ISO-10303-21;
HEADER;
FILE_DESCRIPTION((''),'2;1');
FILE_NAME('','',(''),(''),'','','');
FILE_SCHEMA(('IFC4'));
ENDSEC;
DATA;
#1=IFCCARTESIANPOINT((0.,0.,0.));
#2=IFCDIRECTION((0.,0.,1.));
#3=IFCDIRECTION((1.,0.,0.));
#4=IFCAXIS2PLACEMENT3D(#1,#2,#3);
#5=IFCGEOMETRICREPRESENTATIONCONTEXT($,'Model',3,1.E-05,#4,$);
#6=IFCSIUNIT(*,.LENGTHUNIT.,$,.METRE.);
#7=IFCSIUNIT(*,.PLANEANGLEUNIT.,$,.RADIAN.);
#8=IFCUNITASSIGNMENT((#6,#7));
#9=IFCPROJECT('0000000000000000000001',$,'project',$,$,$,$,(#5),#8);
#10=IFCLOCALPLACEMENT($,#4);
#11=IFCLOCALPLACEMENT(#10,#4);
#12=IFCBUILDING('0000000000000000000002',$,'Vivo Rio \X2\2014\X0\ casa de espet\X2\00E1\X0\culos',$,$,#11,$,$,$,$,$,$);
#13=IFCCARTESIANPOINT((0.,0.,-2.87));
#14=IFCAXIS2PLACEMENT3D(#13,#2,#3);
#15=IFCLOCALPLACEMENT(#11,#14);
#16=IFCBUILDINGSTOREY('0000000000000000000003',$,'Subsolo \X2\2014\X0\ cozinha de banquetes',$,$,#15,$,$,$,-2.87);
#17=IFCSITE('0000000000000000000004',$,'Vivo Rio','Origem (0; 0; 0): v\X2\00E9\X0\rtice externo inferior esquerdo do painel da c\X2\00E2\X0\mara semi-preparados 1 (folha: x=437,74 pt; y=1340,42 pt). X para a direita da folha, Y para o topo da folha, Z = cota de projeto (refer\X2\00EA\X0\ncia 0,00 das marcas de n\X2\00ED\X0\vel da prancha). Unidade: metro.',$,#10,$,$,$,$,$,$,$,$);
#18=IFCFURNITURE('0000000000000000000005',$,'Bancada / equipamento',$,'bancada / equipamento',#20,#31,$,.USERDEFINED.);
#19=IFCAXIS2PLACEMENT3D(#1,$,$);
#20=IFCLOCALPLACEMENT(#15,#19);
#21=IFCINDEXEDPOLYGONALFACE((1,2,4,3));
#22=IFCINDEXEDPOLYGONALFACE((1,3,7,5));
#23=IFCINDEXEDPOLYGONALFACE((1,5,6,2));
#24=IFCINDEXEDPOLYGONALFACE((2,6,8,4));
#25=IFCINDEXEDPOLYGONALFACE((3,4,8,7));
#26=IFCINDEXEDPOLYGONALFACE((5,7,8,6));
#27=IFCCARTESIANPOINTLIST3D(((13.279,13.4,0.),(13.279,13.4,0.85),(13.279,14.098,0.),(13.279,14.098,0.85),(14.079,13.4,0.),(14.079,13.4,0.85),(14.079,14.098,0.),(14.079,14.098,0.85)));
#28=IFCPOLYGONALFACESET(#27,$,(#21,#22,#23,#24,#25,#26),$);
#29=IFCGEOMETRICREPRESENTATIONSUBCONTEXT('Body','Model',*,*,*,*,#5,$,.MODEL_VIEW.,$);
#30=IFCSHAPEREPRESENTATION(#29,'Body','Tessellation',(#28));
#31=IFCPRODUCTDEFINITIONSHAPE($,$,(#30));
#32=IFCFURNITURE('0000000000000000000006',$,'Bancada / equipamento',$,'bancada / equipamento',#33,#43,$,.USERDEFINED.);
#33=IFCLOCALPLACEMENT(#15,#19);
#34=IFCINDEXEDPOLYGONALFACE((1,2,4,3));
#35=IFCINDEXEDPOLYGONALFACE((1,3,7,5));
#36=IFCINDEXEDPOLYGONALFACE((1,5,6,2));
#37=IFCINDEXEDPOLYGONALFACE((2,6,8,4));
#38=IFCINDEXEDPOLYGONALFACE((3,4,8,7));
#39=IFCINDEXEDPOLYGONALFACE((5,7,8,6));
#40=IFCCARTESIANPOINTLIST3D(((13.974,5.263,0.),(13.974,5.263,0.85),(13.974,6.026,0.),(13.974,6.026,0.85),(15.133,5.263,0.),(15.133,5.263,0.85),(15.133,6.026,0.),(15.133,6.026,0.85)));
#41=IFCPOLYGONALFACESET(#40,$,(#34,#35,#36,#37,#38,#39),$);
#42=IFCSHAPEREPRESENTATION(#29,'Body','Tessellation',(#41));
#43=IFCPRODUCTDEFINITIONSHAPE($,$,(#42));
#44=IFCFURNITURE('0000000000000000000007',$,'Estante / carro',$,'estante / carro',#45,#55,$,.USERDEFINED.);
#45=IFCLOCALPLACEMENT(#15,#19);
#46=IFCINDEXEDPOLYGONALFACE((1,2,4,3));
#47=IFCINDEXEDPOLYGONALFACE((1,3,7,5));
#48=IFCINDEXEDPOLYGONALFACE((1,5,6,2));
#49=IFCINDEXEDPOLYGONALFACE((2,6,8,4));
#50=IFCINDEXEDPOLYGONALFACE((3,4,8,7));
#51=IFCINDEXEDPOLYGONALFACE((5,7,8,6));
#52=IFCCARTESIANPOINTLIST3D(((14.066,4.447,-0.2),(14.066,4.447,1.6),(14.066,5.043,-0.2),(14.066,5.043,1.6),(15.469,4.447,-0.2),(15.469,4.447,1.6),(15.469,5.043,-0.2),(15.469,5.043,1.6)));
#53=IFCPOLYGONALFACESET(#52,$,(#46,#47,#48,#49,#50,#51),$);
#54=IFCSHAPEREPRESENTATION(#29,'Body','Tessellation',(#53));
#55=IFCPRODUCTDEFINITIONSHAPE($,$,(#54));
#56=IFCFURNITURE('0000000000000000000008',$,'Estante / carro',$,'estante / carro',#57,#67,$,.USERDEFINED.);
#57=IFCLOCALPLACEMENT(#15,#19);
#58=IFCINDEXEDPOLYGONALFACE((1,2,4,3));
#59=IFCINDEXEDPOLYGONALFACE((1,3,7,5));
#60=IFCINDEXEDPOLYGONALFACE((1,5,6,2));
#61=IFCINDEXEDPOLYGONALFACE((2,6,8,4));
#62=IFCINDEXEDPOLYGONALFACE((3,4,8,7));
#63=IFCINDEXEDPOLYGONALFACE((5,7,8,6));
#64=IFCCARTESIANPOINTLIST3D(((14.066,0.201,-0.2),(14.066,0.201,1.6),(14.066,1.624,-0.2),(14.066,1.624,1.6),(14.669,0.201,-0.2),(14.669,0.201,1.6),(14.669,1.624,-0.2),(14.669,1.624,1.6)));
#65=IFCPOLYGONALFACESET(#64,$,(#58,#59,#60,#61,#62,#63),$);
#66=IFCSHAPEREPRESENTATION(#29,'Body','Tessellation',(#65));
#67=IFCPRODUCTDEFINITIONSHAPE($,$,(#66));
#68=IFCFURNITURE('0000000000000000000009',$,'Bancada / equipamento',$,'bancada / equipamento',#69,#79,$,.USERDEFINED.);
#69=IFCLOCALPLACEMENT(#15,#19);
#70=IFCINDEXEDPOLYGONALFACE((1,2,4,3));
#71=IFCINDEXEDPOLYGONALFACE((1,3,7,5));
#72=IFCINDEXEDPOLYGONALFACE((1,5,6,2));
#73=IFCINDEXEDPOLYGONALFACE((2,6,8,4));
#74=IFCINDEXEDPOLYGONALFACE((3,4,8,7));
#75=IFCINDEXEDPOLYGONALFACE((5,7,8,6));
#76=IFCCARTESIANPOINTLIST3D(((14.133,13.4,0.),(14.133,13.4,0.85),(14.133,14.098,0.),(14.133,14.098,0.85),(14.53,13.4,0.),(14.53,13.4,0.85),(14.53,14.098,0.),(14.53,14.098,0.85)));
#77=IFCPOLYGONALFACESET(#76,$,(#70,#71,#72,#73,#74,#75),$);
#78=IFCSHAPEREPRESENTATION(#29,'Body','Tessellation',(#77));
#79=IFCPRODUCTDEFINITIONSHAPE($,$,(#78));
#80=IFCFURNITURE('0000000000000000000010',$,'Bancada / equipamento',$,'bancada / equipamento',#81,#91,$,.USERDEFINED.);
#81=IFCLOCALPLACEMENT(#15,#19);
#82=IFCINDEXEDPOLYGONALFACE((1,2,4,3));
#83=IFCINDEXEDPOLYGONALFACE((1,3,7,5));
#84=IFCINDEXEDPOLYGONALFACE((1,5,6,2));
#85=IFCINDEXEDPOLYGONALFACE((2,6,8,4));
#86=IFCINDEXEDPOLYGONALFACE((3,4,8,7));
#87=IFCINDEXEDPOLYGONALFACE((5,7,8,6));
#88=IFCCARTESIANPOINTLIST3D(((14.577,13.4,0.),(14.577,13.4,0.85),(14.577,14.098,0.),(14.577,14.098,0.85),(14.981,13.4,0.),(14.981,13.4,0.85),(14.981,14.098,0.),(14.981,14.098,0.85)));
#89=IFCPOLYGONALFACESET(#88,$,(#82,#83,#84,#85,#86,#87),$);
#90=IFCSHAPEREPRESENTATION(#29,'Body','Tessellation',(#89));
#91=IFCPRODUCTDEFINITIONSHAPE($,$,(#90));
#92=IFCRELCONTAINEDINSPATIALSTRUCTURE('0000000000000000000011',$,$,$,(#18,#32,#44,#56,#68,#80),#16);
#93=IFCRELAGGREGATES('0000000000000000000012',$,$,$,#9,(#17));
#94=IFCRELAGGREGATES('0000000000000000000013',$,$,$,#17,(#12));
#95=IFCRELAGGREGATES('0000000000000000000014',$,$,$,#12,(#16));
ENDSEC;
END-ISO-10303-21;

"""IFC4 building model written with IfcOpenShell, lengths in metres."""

from ifc_helpers import new_model, si_unit, frame, origin_with_axes, origin_2d, place, context, subcontext, project, spatial, rectangle, extrude, element, save


model = new_model("IFC4")

# Units and contexts
model_context = context("Model", 3, precision=1e-05, world=origin_with_axes())
body_context = subcontext(model_context, "Body", "Model", "MODEL_VIEW")
ifc_project = project(units=[si_unit("LENGTHUNIT", "METRE"), si_unit("PLANEANGLEUNIT", "RADIAN")], contexts=[model_context])

# Site, building, storey
site_placement = place(None, origin_with_axes())
site = spatial("IfcSite", under=ifc_project, at=site_placement, Name="Vivo Rio", Description="Origem (0; 0; 0): vértice externo inferior esquerdo do painel da câmara semi-preparados 1 (folha: x=437,74 pt; y=1340,42 pt). X para a direita da folha, Y para o topo da folha, Z = cota de projeto (referência 0,00 das marcas de nível da prancha). Unidade: metro.")
building_placement = place(site_placement, origin_with_axes())
building = spatial("IfcBuilding", under=site, at=building_placement, Name="Vivo Rio — casa de espetáculos")
storey_placement = place(building_placement, frame((0.0, 0.0, -2.87), z_axis=(0.0, 0.0, 1.0), x_axis=(1.0, 0.0, 0.0)))
storey = spatial("IfcBuildingStorey", under=building, at=storey_placement, Name="Subsolo — cozinha de banquetes", Elevation=-2.87)

# Furniture
furniture_1_placement = place(storey_placement, origin_with_axes())
element("IfcFurniture", 1, at=furniture_1_placement, inside=storey, Name="Bancada / equipamento", ObjectType="bancada / equipamento", PredefinedType="USERDEFINED", context=body_context, shape_type="SweptSolid", body=[
    extrude(rectangle(XDim=0.8, YDim=0.698, at=origin_2d()), frame((13.679, 13.749, 0.0), z_axis=(0.0, 0.0, 1.0), x_axis=(1.0, 0.0, 0.0)), (0.0, 0.0, 1.0), 0.85),
])
furniture_2_placement = place(storey_placement, origin_with_axes())
element("IfcFurniture", 2, at=furniture_2_placement, inside=storey, Name="Bancada / equipamento", ObjectType="bancada / equipamento", PredefinedType="USERDEFINED", context=body_context, shape_type="SweptSolid", body=[
    extrude(rectangle(XDim=1.159, YDim=0.763, at=origin_2d()), frame((14.5535, 5.6445, 0.0), z_axis=(0.0, 0.0, 1.0), x_axis=(1.0, 0.0, 0.0)), (0.0, 0.0, 1.0), 0.85),
])
furniture_3_placement = place(storey_placement, origin_with_axes())
element("IfcFurniture", 3, at=furniture_3_placement, inside=storey, Name="Estante / carro", ObjectType="estante / carro", PredefinedType="USERDEFINED", context=body_context, shape_type="SweptSolid", body=[
    extrude(rectangle(XDim=1.403, YDim=0.596, at=origin_2d()), frame((14.7675, 4.745, -0.2), z_axis=(0.0, 0.0, 1.0), x_axis=(1.0, 0.0, 0.0)), (0.0, 0.0, 1.0), 1.8),
])
furniture_4_placement = place(storey_placement, origin_with_axes())
element("IfcFurniture", 4, at=furniture_4_placement, inside=storey, Name="Estante / carro", ObjectType="estante / carro", PredefinedType="USERDEFINED", context=body_context, shape_type="SweptSolid", body=[
    extrude(rectangle(XDim=0.603, YDim=1.423, at=origin_2d()), frame((14.3675, 0.9125, -0.2), z_axis=(0.0, 0.0, 1.0), x_axis=(1.0, 0.0, 0.0)), (0.0, 0.0, 1.0), 1.8),
])
furniture_5_placement = place(storey_placement, origin_with_axes())
element("IfcFurniture", 5, at=furniture_5_placement, inside=storey, Name="Bancada / equipamento", ObjectType="bancada / equipamento", PredefinedType="USERDEFINED", context=body_context, shape_type="SweptSolid", body=[
    extrude(rectangle(XDim=0.397, YDim=0.698, at=origin_2d()), frame((14.3315, 13.749, 0.0), z_axis=(0.0, 0.0, 1.0), x_axis=(1.0, 0.0, 0.0)), (0.0, 0.0, 1.0), 0.85),
])
furniture_6_placement = place(storey_placement, origin_with_axes())
element("IfcFurniture", 6, at=furniture_6_placement, inside=storey, Name="Bancada / equipamento", ObjectType="bancada / equipamento", PredefinedType="USERDEFINED", context=body_context, shape_type="SweptSolid", body=[
    extrude(rectangle(XDim=0.404, YDim=0.698, at=origin_2d()), frame((14.779, 13.749, 0.0), z_axis=(0.0, 0.0, 1.0), x_axis=(1.0, 0.0, 0.0)), (0.0, 0.0, 1.0), 0.85),
])

save(model, "model.ifc")
